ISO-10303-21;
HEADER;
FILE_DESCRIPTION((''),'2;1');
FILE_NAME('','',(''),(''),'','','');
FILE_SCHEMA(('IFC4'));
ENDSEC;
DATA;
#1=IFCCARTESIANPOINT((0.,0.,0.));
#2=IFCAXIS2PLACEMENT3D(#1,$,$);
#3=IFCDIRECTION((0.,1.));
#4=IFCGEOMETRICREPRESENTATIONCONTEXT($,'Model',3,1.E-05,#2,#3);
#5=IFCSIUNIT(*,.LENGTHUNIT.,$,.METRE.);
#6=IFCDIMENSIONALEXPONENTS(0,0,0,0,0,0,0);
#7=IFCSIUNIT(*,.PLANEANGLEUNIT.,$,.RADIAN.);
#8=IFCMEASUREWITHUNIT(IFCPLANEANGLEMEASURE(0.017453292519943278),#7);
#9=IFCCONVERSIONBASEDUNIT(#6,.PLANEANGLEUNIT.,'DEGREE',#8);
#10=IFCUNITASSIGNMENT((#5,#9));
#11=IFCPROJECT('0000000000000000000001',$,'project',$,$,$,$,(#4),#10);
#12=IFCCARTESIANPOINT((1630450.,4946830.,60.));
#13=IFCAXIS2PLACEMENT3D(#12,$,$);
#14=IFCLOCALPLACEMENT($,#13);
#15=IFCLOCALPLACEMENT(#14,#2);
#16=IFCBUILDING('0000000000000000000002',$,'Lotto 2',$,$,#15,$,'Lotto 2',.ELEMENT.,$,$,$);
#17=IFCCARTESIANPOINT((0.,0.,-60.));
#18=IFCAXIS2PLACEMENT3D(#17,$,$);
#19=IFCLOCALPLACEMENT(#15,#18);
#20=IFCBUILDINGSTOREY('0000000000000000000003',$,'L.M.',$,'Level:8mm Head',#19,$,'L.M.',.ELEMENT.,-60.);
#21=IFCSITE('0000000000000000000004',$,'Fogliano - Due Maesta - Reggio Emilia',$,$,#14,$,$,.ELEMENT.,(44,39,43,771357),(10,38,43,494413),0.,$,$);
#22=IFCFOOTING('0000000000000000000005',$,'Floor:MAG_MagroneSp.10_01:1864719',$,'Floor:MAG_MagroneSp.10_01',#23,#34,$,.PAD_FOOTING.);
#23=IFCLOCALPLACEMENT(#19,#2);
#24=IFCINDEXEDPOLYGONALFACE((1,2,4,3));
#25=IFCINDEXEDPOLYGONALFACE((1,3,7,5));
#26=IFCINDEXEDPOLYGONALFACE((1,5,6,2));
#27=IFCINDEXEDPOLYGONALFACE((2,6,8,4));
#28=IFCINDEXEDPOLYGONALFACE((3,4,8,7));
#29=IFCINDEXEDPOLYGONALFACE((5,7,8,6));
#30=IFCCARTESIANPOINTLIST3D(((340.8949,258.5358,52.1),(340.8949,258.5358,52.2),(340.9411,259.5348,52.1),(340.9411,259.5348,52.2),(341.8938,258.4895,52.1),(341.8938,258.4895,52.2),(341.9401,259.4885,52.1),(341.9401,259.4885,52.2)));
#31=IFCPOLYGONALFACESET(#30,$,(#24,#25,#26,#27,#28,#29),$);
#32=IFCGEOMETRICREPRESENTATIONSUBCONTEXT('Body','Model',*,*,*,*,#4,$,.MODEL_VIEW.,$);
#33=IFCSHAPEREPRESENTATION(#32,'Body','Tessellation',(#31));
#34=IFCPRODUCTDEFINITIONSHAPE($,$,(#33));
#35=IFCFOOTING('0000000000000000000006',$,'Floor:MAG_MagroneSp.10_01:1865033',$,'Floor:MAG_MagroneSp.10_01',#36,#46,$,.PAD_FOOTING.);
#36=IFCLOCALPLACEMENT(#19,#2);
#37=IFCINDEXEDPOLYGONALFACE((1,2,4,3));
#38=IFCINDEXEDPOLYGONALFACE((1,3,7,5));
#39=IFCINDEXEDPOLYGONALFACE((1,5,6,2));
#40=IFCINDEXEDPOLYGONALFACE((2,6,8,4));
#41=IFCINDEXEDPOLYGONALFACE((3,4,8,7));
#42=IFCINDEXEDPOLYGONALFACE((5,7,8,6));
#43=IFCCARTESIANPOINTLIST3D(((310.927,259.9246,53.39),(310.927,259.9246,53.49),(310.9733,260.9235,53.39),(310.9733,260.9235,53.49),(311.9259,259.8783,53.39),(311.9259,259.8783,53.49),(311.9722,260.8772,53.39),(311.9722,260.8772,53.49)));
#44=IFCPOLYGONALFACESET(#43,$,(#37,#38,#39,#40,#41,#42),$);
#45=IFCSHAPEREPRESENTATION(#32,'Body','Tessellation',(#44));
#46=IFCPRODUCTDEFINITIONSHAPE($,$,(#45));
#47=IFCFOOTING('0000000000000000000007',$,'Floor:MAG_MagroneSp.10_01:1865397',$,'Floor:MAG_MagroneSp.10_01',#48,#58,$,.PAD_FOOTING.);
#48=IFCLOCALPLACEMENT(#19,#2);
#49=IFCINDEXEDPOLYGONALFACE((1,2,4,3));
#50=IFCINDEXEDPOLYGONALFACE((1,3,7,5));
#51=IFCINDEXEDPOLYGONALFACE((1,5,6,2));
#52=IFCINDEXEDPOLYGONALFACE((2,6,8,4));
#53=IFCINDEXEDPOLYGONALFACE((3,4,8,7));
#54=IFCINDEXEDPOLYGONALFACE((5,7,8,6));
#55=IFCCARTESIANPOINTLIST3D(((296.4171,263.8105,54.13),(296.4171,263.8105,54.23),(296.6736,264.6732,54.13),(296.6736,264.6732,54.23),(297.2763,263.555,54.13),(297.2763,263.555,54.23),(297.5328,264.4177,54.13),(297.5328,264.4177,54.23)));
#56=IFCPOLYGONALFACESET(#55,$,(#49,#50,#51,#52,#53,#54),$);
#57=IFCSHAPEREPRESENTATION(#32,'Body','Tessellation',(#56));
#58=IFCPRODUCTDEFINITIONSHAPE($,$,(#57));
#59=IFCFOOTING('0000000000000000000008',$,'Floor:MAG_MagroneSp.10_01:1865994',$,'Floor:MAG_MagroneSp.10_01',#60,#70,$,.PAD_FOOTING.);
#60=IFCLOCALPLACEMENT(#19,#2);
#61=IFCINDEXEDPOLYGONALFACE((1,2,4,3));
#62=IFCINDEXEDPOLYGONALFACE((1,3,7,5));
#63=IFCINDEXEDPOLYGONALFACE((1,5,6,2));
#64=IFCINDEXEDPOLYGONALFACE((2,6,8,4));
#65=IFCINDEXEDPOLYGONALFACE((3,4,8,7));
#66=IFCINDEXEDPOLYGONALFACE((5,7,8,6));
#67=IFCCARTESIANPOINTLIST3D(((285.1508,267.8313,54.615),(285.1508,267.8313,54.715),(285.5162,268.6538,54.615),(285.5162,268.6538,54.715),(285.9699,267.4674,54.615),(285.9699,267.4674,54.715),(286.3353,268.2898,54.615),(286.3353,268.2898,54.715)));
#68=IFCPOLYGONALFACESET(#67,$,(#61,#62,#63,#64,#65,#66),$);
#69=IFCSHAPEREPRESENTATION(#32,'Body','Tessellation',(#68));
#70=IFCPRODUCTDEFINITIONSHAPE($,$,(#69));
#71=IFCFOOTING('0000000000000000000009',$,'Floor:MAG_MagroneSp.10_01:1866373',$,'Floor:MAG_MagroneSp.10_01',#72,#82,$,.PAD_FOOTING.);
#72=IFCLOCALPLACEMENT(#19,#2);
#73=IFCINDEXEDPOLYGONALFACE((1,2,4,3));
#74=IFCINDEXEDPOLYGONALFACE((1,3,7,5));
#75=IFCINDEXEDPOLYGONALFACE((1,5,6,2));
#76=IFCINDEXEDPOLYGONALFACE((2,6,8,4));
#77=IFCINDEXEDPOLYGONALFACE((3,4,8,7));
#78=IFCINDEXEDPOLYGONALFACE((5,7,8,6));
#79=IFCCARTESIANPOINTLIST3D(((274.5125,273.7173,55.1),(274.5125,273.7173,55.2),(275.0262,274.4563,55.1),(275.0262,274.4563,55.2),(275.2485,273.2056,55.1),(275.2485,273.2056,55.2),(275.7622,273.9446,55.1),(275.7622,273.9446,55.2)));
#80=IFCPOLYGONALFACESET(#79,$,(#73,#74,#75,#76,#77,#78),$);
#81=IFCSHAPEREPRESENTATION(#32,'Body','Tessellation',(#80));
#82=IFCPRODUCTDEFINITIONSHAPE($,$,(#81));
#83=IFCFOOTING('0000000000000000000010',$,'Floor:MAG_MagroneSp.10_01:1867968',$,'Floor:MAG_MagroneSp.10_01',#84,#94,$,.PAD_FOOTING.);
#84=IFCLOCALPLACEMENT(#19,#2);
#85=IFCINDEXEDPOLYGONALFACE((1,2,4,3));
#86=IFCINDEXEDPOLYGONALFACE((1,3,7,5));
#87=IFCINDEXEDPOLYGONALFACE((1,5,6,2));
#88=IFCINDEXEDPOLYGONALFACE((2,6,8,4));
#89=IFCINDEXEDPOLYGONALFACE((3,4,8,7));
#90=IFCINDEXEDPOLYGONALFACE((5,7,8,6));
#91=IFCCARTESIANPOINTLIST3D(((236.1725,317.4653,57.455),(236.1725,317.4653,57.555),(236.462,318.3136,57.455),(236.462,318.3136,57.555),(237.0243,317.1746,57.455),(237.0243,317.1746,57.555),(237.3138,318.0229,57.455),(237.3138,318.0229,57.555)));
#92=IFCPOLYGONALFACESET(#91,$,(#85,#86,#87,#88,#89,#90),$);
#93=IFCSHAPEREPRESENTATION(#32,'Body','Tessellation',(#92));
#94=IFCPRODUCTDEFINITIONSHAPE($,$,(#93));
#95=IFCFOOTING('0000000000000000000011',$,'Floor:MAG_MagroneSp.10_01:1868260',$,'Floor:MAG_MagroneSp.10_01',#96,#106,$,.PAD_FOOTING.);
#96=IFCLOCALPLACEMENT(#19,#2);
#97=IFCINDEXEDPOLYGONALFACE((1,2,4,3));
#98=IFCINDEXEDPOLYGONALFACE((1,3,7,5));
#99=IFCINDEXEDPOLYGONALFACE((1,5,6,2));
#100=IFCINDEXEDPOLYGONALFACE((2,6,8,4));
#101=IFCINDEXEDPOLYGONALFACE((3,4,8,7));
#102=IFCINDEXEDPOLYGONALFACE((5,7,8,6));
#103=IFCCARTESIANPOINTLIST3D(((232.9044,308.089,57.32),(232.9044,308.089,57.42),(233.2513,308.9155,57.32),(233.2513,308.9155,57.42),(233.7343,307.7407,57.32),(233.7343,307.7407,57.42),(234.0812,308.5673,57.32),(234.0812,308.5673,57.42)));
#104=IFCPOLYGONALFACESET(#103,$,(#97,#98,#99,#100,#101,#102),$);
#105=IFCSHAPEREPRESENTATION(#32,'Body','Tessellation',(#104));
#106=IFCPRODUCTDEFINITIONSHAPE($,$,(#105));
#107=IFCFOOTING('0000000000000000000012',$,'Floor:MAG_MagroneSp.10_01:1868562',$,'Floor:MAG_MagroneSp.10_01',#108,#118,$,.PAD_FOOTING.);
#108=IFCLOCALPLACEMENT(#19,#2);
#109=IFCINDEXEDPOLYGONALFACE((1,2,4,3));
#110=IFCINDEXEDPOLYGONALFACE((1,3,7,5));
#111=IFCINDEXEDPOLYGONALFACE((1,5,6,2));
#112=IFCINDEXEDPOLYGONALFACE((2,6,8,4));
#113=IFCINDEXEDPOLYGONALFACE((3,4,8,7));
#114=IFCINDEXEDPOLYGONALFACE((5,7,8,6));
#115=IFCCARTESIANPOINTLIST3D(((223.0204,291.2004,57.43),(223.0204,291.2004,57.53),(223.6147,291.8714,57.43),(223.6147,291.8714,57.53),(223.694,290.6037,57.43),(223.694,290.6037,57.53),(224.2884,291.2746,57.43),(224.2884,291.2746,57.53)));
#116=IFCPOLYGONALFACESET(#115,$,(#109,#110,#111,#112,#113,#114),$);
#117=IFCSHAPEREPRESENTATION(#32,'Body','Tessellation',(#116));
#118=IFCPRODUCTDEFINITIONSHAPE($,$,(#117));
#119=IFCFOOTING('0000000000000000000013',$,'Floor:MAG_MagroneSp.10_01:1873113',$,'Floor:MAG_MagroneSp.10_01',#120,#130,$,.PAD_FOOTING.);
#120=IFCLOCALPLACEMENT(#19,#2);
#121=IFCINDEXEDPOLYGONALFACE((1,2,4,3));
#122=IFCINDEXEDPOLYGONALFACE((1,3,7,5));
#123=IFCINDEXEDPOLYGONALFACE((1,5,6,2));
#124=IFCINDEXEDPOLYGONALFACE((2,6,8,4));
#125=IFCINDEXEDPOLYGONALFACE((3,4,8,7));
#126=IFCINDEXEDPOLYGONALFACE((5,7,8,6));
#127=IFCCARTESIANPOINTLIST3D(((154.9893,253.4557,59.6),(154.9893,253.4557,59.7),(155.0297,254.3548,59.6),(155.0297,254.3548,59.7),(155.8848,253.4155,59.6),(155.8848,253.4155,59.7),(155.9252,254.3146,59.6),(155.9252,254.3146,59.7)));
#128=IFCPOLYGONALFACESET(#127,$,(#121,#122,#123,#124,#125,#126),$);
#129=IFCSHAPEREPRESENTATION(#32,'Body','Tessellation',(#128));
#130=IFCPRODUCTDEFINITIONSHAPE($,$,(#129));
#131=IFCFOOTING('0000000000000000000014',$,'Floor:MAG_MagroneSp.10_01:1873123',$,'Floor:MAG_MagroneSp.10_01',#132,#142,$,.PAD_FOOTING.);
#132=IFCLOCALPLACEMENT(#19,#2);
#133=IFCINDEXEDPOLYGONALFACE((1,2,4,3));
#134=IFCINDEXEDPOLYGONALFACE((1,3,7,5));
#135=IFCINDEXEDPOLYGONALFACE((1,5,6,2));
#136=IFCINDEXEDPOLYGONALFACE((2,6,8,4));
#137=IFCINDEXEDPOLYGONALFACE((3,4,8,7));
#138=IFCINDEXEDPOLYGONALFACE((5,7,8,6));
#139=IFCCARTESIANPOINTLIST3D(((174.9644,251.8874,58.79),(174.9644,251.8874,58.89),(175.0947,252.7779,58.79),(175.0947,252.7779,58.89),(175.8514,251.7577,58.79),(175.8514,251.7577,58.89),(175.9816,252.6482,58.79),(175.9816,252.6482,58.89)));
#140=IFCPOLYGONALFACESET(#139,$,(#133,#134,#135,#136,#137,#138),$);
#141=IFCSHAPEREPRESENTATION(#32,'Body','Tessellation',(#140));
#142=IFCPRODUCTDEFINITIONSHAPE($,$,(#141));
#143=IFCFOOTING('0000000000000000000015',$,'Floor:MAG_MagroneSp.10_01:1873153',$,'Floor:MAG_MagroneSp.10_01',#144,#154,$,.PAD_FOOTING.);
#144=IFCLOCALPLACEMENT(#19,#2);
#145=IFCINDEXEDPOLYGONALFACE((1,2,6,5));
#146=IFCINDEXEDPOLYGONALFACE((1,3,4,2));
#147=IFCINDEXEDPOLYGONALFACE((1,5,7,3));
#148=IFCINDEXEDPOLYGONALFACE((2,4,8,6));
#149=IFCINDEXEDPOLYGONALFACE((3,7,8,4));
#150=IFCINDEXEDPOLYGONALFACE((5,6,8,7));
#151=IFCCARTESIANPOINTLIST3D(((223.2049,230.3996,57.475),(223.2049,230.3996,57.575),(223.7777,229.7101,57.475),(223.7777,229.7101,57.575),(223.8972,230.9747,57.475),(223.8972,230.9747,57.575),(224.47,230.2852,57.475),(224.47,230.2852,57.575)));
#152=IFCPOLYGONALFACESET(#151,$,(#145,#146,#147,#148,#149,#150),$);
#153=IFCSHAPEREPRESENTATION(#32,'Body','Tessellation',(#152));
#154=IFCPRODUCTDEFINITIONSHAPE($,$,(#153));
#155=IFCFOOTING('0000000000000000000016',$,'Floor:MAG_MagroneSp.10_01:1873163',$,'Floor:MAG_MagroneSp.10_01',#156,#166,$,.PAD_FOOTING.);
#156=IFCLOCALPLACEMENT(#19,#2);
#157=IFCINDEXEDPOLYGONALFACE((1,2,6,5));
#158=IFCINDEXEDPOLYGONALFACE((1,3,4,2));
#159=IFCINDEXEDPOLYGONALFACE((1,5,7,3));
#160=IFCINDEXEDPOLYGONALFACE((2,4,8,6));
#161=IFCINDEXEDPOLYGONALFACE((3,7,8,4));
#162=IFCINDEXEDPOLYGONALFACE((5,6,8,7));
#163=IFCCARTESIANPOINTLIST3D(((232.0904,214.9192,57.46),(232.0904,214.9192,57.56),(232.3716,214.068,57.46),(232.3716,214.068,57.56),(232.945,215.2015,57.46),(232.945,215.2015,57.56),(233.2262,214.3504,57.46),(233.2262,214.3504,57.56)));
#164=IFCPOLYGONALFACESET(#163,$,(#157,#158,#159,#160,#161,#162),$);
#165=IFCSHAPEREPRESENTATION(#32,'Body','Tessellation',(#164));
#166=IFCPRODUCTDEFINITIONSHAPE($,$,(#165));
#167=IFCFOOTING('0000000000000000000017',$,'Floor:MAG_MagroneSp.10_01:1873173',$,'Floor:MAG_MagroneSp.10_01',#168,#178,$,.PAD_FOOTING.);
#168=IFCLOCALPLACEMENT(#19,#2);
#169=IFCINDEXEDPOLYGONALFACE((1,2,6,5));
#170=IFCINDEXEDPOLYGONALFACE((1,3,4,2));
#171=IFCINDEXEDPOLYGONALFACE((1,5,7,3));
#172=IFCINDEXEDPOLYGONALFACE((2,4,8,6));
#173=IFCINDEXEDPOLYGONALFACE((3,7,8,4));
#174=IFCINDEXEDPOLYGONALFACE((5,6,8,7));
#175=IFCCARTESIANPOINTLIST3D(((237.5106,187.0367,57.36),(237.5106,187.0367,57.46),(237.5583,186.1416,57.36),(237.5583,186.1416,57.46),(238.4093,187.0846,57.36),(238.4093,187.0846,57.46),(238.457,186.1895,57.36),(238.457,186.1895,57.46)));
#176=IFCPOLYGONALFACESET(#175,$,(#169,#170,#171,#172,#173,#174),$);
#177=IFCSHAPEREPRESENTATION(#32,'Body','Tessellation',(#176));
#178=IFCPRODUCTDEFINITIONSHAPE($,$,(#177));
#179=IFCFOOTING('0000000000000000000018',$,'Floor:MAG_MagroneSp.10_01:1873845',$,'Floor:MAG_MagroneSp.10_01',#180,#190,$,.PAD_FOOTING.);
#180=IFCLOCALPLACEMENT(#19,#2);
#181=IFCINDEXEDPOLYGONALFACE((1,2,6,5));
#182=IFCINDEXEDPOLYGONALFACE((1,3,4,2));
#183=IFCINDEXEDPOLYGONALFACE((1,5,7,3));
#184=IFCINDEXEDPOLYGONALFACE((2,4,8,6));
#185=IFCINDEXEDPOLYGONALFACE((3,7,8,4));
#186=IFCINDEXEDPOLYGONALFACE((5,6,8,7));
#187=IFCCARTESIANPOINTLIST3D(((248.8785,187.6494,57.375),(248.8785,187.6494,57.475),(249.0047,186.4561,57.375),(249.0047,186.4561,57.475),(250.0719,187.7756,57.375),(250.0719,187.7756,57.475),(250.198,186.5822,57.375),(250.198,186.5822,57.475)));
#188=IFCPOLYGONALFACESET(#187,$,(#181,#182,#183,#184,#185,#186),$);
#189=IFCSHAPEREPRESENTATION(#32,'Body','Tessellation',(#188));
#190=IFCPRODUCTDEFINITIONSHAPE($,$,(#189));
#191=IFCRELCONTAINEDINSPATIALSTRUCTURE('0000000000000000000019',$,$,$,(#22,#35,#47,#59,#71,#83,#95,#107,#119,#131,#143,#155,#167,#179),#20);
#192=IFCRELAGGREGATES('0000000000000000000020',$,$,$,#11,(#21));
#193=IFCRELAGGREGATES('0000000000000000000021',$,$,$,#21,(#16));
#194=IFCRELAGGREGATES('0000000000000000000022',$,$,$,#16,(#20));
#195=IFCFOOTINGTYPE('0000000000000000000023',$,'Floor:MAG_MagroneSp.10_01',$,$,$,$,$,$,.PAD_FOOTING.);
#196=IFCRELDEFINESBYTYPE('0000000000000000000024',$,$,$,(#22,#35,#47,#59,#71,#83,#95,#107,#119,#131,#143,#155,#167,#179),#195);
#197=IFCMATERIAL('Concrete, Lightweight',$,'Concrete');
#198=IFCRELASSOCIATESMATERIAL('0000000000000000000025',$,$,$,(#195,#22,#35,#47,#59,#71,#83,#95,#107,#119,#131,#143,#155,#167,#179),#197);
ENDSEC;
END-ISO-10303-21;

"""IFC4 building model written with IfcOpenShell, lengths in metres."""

from ifc_helpers import new_model, entity, si_unit, converted_unit, direction, frame, origin, place, context, subcontext, project, spatial, indexed_curve, outline, extrude, material, type_object, element, save


model = new_model("IFC4")

# Units and contexts
model_context = context("Model", 3, precision=1e-05, world=origin(), true_north=direction((0.0, 1.0)))
body_context = subcontext(model_context, "Body", "Model", "MODEL_VIEW")
ifc_project = project(units=[si_unit("LENGTHUNIT", "METRE"), converted_unit("PLANEANGLEUNIT", "DEGREE", entity("IfcPlaneAngleMeasure", 0.017453292519943278), si_unit("PLANEANGLEUNIT", "RADIAN"), dimensions=[0, 0, 0, 0, 0, 0, 0])], contexts=[model_context])

# Site, building, storey
site_placement = place(None, frame((1630450.0, 4946830.0, 60.0)))
site = spatial("IfcSite", under=ifc_project, at=site_placement, Name="Fogliano - Due Maesta - Reggio Emilia", CompositionType="ELEMENT", RefLatitude=(44, 39, 43, 771357), RefLongitude=(10, 38, 43, 494413), RefElevation=0.0)
building_placement = place(site_placement, origin())
building = spatial("IfcBuilding", under=site, at=building_placement, Name="Lotto 2", LongName="Lotto 2", CompositionType="ELEMENT")
storey_placement = place(building_placement, frame((0.0, 0.0, -60.0)))
storey = spatial("IfcBuildingStorey", under=building, at=storey_placement, Name="L.M.", ObjectType="Level:8mm Head", LongName="L.M.", CompositionType="ELEMENT", Elevation=-60.0)

# Footings
ifc_material = material(Name="Concrete, Lightweight", Category="Concrete")
footing_type = type_object("IfcFootingType", Name="Floor:MAG_MagroneSp.10_01", PredefinedType="PAD_FOOTING", material=ifc_material)
footing_1_placement = place(storey_placement, origin())
element("IfcFooting", 1, at=footing_1_placement, inside=storey, type_object=footing_type, material=ifc_material, Name="Floor:MAG_MagroneSp.10_01:1864719", ObjectType="Floor:MAG_MagroneSp.10_01", PredefinedType="PAD_FOOTING", context=body_context, shape_type="SweptSolid", body=[
    extrude(outline(indexed_curve([(-0.5, -0.5), (0.5, -0.5), (0.5, 0.5), (-0.5, 0.5), (-0.5, -0.5)], self_intersect=False)), frame((341.4175, 259.0122, 52.2), z_axis=(0.0, 0.0, -1.0), x_axis=(-0.046292, -0.998928, 0.0)), (0.0, 0.0, 1.0), 0.1),
])
footing_2_placement = place(storey_placement, origin())
element("IfcFooting", 2, at=footing_2_placement, inside=storey, type_object=footing_type, material=ifc_material, Name="Floor:MAG_MagroneSp.10_01:1865033", ObjectType="Floor:MAG_MagroneSp.10_01", PredefinedType="PAD_FOOTING", context=body_context, shape_type="SweptSolid", body=[
    extrude(outline(indexed_curve([(-0.5, -0.5), (0.5, -0.5), (0.5, 0.5), (-0.5, 0.5), (-0.5, -0.5)], self_intersect=False)), frame((311.4496, 260.4009, 53.49), z_axis=(0.0, 0.0, -1.0), x_axis=(-0.046292, -0.998928, 0.0)), (0.0, 0.0, 1.0), 0.1),
])
footing_3_placement = place(storey_placement, origin())
element("IfcFooting", 3, at=footing_3_placement, inside=storey, type_object=footing_type, material=ifc_material, Name="Floor:MAG_MagroneSp.10_01:1865397", ObjectType="Floor:MAG_MagroneSp.10_01", PredefinedType="PAD_FOOTING", context=body_context, shape_type="SweptSolid", body=[
    extrude(outline(indexed_curve([(-0.45, -0.4482), (0.45, -0.4482), (0.45, 0.4482), (-0.45, 0.4482), (-0.45, -0.4482)], self_intersect=False)), frame((296.9749, 264.1141, 54.23), z_axis=(0.0, 0.0, -1.0), x_axis=(-0.28504, -0.958516, 0.0)), (0.0, 0.0, 1.0), 0.1),
])
footing_4_placement = place(storey_placement, origin())
element("IfcFooting", 4, at=footing_4_placement, inside=storey, type_object=footing_type, material=ifc_material, Name="Floor:MAG_MagroneSp.10_01:1865994", ObjectType="Floor:MAG_MagroneSp.10_01", PredefinedType="PAD_FOOTING", context=body_context, shape_type="SweptSolid", body=[
    extrude(outline(indexed_curve([(-0.45, -0.4482), (0.45, -0.4482), (0.45, 0.4482), (-0.45, 0.4482), (-0.45, -0.4482)], self_intersect=False)), frame((285.7431, 268.0606, 54.715), z_axis=(0.0, 0.0, -1.0), x_axis=(-0.406033, -0.913858, 0.0)), (0.0, 0.0, 1.0), 0.1),
])
footing_5_placement = place(storey_placement, origin())
element("IfcFooting", 5, at=footing_5_placement, inside=storey, type_object=footing_type, material=ifc_material, Name="Floor:MAG_MagroneSp.10_01:1866373", ObjectType="Floor:MAG_MagroneSp.10_01", PredefinedType="PAD_FOOTING", context=body_context, shape_type="SweptSolid", body=[
    extrude(outline(indexed_curve([(-0.45, -0.4482), (0.45, -0.4482), (0.45, 0.4482), (-0.45, 0.4482), (-0.45, -0.4482)], self_intersect=False)), frame((275.1373, 273.8309, 55.2), z_axis=(0.0, 0.0, -1.0), x_axis=(-0.570822, -0.821074, 0.0)), (0.0, 0.0, 1.0), 0.1),
])
footing_6_placement = place(storey_placement, origin())
element("IfcFooting", 6, at=footing_6_placement, inside=storey, type_object=footing_type, material=ifc_material, Name="Floor:MAG_MagroneSp.10_01:1867968", ObjectType="Floor:MAG_MagroneSp.10_01", PredefinedType="PAD_FOOTING", context=body_context, shape_type="SweptSolid", body=[
    extrude(outline(indexed_curve([(-0.4482, -0.45), (0.4482, -0.45), (0.4482, 0.45), (-0.4482, 0.45), (-0.4482, -0.45)], self_intersect=False)), frame((236.7431, 317.7441, 57.555), z_axis=(0.0, 0.0, -1.0), x_axis=(-0.322977, -0.946407, 0.0)), (0.0, 0.0, 1.0), 0.1),
])
footing_7_placement = place(storey_placement, origin())
element("IfcFooting", 7, at=footing_7_placement, inside=storey, type_object=footing_type, material=ifc_material, Name="Floor:MAG_MagroneSp.10_01:1868260", ObjectType="Floor:MAG_MagroneSp.10_01", PredefinedType="PAD_FOOTING", context=body_context, shape_type="SweptSolid", body=[
    extrude(outline(indexed_curve([(-0.4482, -0.45), (0.4482, -0.45), (0.4482, 0.45), (-0.4482, 0.45), (-0.4482, -0.45)], self_intersect=False)), frame((233.4928, 308.3281, 57.42), z_axis=(0.0, 0.0, -1.0), x_axis=(-0.386929, -0.922109, 0.0)), (0.0, 0.0, 1.0), 0.1),
])
footing_8_placement = place(storey_placement, origin())
element("IfcFooting", 8, at=footing_8_placement, inside=storey, type_object=footing_type, material=ifc_material, Name="Floor:MAG_MagroneSp.10_01:1868562", ObjectType="Floor:MAG_MagroneSp.10_01", PredefinedType="PAD_FOOTING", context=body_context, shape_type="SweptSolid", body=[
    extrude(outline(indexed_curve([(-0.45, -0.4482), (0.45, -0.4482), (0.45, 0.4482), (-0.45, 0.4482), (-0.45, -0.4482)], self_intersect=False)), frame((223.6544, 291.2375, 57.53), z_axis=(0.0, 0.0, -1.0), x_axis=(0.748529, -0.663102, 0.0)), (0.0, 0.0, 1.0), 0.1),
])
footing_9_placement = place(storey_placement, origin())
element("IfcFooting", 9, at=footing_9_placement, inside=storey, type_object=footing_type, material=ifc_material, Name="Floor:MAG_MagroneSp.10_01:1873113", ObjectType="Floor:MAG_MagroneSp.10_01", PredefinedType="PAD_FOOTING", context=body_context, shape_type="SweptSolid", body=[
    extrude(outline(indexed_curve([(-0.4482, -0.45), (0.4482, -0.45), (0.4482, 0.45), (-0.4482, 0.45), (-0.4482, -0.45)], self_intersect=False)), frame((155.4573, 253.8851, 59.7), z_axis=(0.0, 0.0, -1.0), x_axis=(0.998994, -0.044843, 0.0)), (0.0, 0.0, 1.0), 0.1),
])
footing_10_placement = place(storey_placement, origin())
element("IfcFooting", 10, at=footing_10_placement, inside=storey, type_object=footing_type, material=ifc_material, Name="Floor:MAG_MagroneSp.10_01:1873123", ObjectType="Floor:MAG_MagroneSp.10_01", PredefinedType="PAD_FOOTING", context=body_context, shape_type="SweptSolid", body=[
    extrude(outline(indexed_curve([(-0.4482, -0.45), (0.4482, -0.45), (0.4482, 0.45), (-0.4482, 0.45), (-0.4482, -0.45)], self_intersect=False)), frame((175.473, 252.2678, 58.89), z_axis=(0.0, 0.0, -1.0), x_axis=(0.98948, -0.144671, 0.0)), (0.0, 0.0, 1.0), 0.1),
])
footing_11_placement = place(storey_placement, origin())
element("IfcFooting", 11, at=footing_11_placement, inside=storey, type_object=footing_type, material=ifc_material, Name="Floor:MAG_MagroneSp.10_01:1873153", ObjectType="Floor:MAG_MagroneSp.10_01", PredefinedType="PAD_FOOTING", context=body_context, shape_type="SweptSolid", body=[
    extrude(outline(indexed_curve([(-0.4482, -0.45), (0.4482, -0.45), (0.4482, 0.45), (-0.4482, 0.45), (-0.4482, -0.45)], self_intersect=False)), frame((223.8374, 230.3424, 57.575), z_axis=(0.0, 0.0, -1.0), x_axis=(0.638982, -0.769221, 0.0)), (0.0, 0.0, 1.0), 0.1),
])
footing_12_placement = place(storey_placement, origin())
element("IfcFooting", 12, at=footing_12_placement, inside=storey, type_object=footing_type, material=ifc_material, Name="Floor:MAG_MagroneSp.10_01:1873163", ObjectType="Floor:MAG_MagroneSp.10_01", PredefinedType="PAD_FOOTING", context=body_context, shape_type="SweptSolid", body=[
    extrude(outline(indexed_curve([(-0.45, -0.4482), (0.45, -0.4482), (0.45, 0.4482), (-0.45, 0.4482), (-0.45, -0.4482)], self_intersect=False)), frame((232.6583, 214.6348, 57.56), z_axis=(0.0, 0.0, -1.0), x_axis=(0.949529, 0.313681, 0.0)), (0.0, 0.0, 1.0), 0.1),
])
footing_13_placement = place(storey_placement, origin())
element("IfcFooting", 13, at=footing_13_placement, inside=storey, type_object=footing_type, material=ifc_material, Name="Floor:MAG_MagroneSp.10_01:1873173", ObjectType="Floor:MAG_MagroneSp.10_01", PredefinedType="PAD_FOOTING", context=body_context, shape_type="SweptSolid", body=[
    extrude(outline(indexed_curve([(-0.45, -0.4482), (0.45, -0.4482), (0.45, 0.4482), (-0.45, 0.4482), (-0.45, -0.4482)], self_intersect=False)), frame((237.9838, 186.6131, 57.46), z_axis=(0.0, 0.0, -1.0), x_axis=(0.998583, 0.053224, 0.0)), (0.0, 0.0, 1.0), 0.1),
])
footing_14_placement = place(storey_placement, origin())
element("IfcFooting", 14, at=footing_14_placement, inside=storey, type_object=footing_type, material=ifc_material, Name="Floor:MAG_MagroneSp.10_01:1873845", ObjectType="Floor:MAG_MagroneSp.10_01", PredefinedType="PAD_FOOTING", context=body_context, shape_type="SweptSolid", body=[
    extrude(outline(indexed_curve([(-0.6, -0.6), (0.6, -0.6), (0.6, 0.6), (-0.6, 0.6), (-0.6, -0.6)], self_intersect=False)), frame((249.5383, 187.1158, 57.475), z_axis=(0.0, 0.0, -1.0), x_axis=(0.105116, -0.99446, 0.0)), (0.0, 0.0, 1.0), 0.1),
])

save(model, "model.ifc")
